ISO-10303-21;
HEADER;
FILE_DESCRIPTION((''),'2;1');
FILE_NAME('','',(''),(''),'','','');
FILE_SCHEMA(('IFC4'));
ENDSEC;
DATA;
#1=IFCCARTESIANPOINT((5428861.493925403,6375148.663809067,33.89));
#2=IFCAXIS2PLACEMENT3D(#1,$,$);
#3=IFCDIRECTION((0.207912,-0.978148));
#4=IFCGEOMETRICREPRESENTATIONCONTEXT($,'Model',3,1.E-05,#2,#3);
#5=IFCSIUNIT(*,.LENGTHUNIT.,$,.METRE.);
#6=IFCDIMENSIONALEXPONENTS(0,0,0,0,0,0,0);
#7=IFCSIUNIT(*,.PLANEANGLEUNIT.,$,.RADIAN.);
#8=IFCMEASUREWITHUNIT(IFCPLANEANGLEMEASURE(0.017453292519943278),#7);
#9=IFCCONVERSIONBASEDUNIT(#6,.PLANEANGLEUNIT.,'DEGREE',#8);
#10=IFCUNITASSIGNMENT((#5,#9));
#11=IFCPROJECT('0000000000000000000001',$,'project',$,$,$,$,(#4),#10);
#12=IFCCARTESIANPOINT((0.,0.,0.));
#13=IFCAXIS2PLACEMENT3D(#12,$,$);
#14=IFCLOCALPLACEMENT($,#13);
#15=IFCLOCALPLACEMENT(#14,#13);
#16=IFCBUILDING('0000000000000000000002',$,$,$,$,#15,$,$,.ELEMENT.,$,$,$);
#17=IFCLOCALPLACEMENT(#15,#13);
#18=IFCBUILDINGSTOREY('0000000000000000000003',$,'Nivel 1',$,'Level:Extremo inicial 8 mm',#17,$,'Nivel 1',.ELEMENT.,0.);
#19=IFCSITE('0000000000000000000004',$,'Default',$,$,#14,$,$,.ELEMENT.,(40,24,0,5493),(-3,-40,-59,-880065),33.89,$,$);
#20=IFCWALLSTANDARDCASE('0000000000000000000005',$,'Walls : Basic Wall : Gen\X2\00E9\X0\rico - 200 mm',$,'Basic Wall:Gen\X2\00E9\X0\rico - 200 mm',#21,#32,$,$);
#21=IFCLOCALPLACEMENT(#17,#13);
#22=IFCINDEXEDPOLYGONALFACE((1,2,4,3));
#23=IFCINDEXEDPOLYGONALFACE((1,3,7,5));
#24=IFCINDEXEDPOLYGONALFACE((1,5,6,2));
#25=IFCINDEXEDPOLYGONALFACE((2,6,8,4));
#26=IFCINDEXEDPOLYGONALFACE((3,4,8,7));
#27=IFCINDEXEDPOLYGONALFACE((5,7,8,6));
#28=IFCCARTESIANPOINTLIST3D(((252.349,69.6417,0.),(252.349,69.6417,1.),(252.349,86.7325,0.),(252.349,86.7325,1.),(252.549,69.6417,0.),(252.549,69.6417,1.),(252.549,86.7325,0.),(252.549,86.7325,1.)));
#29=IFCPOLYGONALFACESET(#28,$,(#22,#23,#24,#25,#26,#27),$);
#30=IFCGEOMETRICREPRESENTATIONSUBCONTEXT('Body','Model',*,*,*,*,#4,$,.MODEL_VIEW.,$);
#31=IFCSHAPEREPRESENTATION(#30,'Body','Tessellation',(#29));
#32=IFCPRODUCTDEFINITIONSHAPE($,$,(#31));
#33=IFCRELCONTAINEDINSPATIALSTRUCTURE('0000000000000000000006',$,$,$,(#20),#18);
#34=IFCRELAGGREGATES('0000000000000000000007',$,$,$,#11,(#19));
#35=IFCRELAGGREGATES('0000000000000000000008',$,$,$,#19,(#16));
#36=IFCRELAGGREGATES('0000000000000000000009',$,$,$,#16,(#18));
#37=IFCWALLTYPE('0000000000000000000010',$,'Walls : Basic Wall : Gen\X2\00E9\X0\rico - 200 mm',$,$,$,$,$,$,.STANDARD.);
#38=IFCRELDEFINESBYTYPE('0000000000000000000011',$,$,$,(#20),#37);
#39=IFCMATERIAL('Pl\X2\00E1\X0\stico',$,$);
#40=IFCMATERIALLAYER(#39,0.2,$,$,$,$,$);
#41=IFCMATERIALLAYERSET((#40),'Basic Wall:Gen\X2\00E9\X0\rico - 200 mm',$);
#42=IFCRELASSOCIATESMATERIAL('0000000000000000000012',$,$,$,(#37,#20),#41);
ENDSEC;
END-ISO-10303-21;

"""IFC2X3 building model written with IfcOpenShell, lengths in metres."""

from ifc_helpers import new_model, entity, si_unit, converted_unit, direction, frame, frame_2d, origin, place, context, subcontext, project, spatial, rectangle, extrude, material, layer, layer_set, layer_usage, type_object, element, save


model = new_model("IFC2X3")

# Units and contexts
model_context = context("Model", 3, precision=1e-05, world=frame((5428861.493925403, 6375148.663809067, 33.89)), true_north=direction((0.207912, -0.978148)))
body_context = subcontext(model_context, "Body", "Model", "MODEL_VIEW")
ifc_project = project(units=[si_unit("LENGTHUNIT", "METRE"), converted_unit("PLANEANGLEUNIT", "DEGREE", entity("IfcPlaneAngleMeasure", 0.017453292519943278), si_unit("PLANEANGLEUNIT", "RADIAN"), dimensions=[0, 0, 0, 0, 0, 0, 0])], contexts=[model_context])

# Site, building, storey
site_placement = place(None, origin())
site = spatial("IfcSite", under=ifc_project, at=site_placement, Name="Default", CompositionType="ELEMENT", RefLatitude=(40, 24, 0, 5493), RefLongitude=(-3, -40, -59, -880065), RefElevation=33.89)
building_placement = place(site_placement, origin())
building = spatial("IfcBuilding", under=site, at=building_placement, CompositionType="ELEMENT")
storey_placement = place(building_placement, origin())
storey = spatial("IfcBuildingStorey", under=building, at=storey_placement, Name="Nivel 1", ObjectType="Level:Extremo inicial 8 mm", LongName="Nivel 1", CompositionType="ELEMENT", Elevation=0.0)

# Wall
ifc_material_1 = material(Name="Plástico")
ifc_layer_1 = layer(ifc_material_1, 0.2)
ifc_layer_set_1 = layer_set([ifc_layer_1], Name="Basic Wall:Genérico - 200 mm")
wall_type = type_object("IfcWallType", Name="Walls : Basic Wall : Genérico - 200 mm", PredefinedType="STANDARD", material=ifc_layer_set_1)
ifc_layer_usage_1 = layer_usage(ifc_layer_set_1, "AXIS2", "NEGATIVE", 0.1)
wall_1_placement = place(storey_placement, frame((252.449, 69.6417, 0.0), z_axis=(0.0, 0.0, 1.0), x_axis=(0.0, 1.0, 0.0)))
element("IfcWallStandardCase", 1, at=wall_1_placement, inside=storey, type_object=wall_type, material=ifc_layer_usage_1, Name="Walls : Basic Wall : Genérico - 200 mm", ObjectType="Basic Wall:Genérico - 200 mm", context=body_context, shape_type="SweptSolid", body=[
    extrude(rectangle(XDim=17.0908, YDim=0.2, at=frame_2d((8.5454, 0.0), x_axis=(-1.0, 0.0))), origin(), (0.0, 0.0, 1.0), 1.0),
])

save(model, "model.ifc")
